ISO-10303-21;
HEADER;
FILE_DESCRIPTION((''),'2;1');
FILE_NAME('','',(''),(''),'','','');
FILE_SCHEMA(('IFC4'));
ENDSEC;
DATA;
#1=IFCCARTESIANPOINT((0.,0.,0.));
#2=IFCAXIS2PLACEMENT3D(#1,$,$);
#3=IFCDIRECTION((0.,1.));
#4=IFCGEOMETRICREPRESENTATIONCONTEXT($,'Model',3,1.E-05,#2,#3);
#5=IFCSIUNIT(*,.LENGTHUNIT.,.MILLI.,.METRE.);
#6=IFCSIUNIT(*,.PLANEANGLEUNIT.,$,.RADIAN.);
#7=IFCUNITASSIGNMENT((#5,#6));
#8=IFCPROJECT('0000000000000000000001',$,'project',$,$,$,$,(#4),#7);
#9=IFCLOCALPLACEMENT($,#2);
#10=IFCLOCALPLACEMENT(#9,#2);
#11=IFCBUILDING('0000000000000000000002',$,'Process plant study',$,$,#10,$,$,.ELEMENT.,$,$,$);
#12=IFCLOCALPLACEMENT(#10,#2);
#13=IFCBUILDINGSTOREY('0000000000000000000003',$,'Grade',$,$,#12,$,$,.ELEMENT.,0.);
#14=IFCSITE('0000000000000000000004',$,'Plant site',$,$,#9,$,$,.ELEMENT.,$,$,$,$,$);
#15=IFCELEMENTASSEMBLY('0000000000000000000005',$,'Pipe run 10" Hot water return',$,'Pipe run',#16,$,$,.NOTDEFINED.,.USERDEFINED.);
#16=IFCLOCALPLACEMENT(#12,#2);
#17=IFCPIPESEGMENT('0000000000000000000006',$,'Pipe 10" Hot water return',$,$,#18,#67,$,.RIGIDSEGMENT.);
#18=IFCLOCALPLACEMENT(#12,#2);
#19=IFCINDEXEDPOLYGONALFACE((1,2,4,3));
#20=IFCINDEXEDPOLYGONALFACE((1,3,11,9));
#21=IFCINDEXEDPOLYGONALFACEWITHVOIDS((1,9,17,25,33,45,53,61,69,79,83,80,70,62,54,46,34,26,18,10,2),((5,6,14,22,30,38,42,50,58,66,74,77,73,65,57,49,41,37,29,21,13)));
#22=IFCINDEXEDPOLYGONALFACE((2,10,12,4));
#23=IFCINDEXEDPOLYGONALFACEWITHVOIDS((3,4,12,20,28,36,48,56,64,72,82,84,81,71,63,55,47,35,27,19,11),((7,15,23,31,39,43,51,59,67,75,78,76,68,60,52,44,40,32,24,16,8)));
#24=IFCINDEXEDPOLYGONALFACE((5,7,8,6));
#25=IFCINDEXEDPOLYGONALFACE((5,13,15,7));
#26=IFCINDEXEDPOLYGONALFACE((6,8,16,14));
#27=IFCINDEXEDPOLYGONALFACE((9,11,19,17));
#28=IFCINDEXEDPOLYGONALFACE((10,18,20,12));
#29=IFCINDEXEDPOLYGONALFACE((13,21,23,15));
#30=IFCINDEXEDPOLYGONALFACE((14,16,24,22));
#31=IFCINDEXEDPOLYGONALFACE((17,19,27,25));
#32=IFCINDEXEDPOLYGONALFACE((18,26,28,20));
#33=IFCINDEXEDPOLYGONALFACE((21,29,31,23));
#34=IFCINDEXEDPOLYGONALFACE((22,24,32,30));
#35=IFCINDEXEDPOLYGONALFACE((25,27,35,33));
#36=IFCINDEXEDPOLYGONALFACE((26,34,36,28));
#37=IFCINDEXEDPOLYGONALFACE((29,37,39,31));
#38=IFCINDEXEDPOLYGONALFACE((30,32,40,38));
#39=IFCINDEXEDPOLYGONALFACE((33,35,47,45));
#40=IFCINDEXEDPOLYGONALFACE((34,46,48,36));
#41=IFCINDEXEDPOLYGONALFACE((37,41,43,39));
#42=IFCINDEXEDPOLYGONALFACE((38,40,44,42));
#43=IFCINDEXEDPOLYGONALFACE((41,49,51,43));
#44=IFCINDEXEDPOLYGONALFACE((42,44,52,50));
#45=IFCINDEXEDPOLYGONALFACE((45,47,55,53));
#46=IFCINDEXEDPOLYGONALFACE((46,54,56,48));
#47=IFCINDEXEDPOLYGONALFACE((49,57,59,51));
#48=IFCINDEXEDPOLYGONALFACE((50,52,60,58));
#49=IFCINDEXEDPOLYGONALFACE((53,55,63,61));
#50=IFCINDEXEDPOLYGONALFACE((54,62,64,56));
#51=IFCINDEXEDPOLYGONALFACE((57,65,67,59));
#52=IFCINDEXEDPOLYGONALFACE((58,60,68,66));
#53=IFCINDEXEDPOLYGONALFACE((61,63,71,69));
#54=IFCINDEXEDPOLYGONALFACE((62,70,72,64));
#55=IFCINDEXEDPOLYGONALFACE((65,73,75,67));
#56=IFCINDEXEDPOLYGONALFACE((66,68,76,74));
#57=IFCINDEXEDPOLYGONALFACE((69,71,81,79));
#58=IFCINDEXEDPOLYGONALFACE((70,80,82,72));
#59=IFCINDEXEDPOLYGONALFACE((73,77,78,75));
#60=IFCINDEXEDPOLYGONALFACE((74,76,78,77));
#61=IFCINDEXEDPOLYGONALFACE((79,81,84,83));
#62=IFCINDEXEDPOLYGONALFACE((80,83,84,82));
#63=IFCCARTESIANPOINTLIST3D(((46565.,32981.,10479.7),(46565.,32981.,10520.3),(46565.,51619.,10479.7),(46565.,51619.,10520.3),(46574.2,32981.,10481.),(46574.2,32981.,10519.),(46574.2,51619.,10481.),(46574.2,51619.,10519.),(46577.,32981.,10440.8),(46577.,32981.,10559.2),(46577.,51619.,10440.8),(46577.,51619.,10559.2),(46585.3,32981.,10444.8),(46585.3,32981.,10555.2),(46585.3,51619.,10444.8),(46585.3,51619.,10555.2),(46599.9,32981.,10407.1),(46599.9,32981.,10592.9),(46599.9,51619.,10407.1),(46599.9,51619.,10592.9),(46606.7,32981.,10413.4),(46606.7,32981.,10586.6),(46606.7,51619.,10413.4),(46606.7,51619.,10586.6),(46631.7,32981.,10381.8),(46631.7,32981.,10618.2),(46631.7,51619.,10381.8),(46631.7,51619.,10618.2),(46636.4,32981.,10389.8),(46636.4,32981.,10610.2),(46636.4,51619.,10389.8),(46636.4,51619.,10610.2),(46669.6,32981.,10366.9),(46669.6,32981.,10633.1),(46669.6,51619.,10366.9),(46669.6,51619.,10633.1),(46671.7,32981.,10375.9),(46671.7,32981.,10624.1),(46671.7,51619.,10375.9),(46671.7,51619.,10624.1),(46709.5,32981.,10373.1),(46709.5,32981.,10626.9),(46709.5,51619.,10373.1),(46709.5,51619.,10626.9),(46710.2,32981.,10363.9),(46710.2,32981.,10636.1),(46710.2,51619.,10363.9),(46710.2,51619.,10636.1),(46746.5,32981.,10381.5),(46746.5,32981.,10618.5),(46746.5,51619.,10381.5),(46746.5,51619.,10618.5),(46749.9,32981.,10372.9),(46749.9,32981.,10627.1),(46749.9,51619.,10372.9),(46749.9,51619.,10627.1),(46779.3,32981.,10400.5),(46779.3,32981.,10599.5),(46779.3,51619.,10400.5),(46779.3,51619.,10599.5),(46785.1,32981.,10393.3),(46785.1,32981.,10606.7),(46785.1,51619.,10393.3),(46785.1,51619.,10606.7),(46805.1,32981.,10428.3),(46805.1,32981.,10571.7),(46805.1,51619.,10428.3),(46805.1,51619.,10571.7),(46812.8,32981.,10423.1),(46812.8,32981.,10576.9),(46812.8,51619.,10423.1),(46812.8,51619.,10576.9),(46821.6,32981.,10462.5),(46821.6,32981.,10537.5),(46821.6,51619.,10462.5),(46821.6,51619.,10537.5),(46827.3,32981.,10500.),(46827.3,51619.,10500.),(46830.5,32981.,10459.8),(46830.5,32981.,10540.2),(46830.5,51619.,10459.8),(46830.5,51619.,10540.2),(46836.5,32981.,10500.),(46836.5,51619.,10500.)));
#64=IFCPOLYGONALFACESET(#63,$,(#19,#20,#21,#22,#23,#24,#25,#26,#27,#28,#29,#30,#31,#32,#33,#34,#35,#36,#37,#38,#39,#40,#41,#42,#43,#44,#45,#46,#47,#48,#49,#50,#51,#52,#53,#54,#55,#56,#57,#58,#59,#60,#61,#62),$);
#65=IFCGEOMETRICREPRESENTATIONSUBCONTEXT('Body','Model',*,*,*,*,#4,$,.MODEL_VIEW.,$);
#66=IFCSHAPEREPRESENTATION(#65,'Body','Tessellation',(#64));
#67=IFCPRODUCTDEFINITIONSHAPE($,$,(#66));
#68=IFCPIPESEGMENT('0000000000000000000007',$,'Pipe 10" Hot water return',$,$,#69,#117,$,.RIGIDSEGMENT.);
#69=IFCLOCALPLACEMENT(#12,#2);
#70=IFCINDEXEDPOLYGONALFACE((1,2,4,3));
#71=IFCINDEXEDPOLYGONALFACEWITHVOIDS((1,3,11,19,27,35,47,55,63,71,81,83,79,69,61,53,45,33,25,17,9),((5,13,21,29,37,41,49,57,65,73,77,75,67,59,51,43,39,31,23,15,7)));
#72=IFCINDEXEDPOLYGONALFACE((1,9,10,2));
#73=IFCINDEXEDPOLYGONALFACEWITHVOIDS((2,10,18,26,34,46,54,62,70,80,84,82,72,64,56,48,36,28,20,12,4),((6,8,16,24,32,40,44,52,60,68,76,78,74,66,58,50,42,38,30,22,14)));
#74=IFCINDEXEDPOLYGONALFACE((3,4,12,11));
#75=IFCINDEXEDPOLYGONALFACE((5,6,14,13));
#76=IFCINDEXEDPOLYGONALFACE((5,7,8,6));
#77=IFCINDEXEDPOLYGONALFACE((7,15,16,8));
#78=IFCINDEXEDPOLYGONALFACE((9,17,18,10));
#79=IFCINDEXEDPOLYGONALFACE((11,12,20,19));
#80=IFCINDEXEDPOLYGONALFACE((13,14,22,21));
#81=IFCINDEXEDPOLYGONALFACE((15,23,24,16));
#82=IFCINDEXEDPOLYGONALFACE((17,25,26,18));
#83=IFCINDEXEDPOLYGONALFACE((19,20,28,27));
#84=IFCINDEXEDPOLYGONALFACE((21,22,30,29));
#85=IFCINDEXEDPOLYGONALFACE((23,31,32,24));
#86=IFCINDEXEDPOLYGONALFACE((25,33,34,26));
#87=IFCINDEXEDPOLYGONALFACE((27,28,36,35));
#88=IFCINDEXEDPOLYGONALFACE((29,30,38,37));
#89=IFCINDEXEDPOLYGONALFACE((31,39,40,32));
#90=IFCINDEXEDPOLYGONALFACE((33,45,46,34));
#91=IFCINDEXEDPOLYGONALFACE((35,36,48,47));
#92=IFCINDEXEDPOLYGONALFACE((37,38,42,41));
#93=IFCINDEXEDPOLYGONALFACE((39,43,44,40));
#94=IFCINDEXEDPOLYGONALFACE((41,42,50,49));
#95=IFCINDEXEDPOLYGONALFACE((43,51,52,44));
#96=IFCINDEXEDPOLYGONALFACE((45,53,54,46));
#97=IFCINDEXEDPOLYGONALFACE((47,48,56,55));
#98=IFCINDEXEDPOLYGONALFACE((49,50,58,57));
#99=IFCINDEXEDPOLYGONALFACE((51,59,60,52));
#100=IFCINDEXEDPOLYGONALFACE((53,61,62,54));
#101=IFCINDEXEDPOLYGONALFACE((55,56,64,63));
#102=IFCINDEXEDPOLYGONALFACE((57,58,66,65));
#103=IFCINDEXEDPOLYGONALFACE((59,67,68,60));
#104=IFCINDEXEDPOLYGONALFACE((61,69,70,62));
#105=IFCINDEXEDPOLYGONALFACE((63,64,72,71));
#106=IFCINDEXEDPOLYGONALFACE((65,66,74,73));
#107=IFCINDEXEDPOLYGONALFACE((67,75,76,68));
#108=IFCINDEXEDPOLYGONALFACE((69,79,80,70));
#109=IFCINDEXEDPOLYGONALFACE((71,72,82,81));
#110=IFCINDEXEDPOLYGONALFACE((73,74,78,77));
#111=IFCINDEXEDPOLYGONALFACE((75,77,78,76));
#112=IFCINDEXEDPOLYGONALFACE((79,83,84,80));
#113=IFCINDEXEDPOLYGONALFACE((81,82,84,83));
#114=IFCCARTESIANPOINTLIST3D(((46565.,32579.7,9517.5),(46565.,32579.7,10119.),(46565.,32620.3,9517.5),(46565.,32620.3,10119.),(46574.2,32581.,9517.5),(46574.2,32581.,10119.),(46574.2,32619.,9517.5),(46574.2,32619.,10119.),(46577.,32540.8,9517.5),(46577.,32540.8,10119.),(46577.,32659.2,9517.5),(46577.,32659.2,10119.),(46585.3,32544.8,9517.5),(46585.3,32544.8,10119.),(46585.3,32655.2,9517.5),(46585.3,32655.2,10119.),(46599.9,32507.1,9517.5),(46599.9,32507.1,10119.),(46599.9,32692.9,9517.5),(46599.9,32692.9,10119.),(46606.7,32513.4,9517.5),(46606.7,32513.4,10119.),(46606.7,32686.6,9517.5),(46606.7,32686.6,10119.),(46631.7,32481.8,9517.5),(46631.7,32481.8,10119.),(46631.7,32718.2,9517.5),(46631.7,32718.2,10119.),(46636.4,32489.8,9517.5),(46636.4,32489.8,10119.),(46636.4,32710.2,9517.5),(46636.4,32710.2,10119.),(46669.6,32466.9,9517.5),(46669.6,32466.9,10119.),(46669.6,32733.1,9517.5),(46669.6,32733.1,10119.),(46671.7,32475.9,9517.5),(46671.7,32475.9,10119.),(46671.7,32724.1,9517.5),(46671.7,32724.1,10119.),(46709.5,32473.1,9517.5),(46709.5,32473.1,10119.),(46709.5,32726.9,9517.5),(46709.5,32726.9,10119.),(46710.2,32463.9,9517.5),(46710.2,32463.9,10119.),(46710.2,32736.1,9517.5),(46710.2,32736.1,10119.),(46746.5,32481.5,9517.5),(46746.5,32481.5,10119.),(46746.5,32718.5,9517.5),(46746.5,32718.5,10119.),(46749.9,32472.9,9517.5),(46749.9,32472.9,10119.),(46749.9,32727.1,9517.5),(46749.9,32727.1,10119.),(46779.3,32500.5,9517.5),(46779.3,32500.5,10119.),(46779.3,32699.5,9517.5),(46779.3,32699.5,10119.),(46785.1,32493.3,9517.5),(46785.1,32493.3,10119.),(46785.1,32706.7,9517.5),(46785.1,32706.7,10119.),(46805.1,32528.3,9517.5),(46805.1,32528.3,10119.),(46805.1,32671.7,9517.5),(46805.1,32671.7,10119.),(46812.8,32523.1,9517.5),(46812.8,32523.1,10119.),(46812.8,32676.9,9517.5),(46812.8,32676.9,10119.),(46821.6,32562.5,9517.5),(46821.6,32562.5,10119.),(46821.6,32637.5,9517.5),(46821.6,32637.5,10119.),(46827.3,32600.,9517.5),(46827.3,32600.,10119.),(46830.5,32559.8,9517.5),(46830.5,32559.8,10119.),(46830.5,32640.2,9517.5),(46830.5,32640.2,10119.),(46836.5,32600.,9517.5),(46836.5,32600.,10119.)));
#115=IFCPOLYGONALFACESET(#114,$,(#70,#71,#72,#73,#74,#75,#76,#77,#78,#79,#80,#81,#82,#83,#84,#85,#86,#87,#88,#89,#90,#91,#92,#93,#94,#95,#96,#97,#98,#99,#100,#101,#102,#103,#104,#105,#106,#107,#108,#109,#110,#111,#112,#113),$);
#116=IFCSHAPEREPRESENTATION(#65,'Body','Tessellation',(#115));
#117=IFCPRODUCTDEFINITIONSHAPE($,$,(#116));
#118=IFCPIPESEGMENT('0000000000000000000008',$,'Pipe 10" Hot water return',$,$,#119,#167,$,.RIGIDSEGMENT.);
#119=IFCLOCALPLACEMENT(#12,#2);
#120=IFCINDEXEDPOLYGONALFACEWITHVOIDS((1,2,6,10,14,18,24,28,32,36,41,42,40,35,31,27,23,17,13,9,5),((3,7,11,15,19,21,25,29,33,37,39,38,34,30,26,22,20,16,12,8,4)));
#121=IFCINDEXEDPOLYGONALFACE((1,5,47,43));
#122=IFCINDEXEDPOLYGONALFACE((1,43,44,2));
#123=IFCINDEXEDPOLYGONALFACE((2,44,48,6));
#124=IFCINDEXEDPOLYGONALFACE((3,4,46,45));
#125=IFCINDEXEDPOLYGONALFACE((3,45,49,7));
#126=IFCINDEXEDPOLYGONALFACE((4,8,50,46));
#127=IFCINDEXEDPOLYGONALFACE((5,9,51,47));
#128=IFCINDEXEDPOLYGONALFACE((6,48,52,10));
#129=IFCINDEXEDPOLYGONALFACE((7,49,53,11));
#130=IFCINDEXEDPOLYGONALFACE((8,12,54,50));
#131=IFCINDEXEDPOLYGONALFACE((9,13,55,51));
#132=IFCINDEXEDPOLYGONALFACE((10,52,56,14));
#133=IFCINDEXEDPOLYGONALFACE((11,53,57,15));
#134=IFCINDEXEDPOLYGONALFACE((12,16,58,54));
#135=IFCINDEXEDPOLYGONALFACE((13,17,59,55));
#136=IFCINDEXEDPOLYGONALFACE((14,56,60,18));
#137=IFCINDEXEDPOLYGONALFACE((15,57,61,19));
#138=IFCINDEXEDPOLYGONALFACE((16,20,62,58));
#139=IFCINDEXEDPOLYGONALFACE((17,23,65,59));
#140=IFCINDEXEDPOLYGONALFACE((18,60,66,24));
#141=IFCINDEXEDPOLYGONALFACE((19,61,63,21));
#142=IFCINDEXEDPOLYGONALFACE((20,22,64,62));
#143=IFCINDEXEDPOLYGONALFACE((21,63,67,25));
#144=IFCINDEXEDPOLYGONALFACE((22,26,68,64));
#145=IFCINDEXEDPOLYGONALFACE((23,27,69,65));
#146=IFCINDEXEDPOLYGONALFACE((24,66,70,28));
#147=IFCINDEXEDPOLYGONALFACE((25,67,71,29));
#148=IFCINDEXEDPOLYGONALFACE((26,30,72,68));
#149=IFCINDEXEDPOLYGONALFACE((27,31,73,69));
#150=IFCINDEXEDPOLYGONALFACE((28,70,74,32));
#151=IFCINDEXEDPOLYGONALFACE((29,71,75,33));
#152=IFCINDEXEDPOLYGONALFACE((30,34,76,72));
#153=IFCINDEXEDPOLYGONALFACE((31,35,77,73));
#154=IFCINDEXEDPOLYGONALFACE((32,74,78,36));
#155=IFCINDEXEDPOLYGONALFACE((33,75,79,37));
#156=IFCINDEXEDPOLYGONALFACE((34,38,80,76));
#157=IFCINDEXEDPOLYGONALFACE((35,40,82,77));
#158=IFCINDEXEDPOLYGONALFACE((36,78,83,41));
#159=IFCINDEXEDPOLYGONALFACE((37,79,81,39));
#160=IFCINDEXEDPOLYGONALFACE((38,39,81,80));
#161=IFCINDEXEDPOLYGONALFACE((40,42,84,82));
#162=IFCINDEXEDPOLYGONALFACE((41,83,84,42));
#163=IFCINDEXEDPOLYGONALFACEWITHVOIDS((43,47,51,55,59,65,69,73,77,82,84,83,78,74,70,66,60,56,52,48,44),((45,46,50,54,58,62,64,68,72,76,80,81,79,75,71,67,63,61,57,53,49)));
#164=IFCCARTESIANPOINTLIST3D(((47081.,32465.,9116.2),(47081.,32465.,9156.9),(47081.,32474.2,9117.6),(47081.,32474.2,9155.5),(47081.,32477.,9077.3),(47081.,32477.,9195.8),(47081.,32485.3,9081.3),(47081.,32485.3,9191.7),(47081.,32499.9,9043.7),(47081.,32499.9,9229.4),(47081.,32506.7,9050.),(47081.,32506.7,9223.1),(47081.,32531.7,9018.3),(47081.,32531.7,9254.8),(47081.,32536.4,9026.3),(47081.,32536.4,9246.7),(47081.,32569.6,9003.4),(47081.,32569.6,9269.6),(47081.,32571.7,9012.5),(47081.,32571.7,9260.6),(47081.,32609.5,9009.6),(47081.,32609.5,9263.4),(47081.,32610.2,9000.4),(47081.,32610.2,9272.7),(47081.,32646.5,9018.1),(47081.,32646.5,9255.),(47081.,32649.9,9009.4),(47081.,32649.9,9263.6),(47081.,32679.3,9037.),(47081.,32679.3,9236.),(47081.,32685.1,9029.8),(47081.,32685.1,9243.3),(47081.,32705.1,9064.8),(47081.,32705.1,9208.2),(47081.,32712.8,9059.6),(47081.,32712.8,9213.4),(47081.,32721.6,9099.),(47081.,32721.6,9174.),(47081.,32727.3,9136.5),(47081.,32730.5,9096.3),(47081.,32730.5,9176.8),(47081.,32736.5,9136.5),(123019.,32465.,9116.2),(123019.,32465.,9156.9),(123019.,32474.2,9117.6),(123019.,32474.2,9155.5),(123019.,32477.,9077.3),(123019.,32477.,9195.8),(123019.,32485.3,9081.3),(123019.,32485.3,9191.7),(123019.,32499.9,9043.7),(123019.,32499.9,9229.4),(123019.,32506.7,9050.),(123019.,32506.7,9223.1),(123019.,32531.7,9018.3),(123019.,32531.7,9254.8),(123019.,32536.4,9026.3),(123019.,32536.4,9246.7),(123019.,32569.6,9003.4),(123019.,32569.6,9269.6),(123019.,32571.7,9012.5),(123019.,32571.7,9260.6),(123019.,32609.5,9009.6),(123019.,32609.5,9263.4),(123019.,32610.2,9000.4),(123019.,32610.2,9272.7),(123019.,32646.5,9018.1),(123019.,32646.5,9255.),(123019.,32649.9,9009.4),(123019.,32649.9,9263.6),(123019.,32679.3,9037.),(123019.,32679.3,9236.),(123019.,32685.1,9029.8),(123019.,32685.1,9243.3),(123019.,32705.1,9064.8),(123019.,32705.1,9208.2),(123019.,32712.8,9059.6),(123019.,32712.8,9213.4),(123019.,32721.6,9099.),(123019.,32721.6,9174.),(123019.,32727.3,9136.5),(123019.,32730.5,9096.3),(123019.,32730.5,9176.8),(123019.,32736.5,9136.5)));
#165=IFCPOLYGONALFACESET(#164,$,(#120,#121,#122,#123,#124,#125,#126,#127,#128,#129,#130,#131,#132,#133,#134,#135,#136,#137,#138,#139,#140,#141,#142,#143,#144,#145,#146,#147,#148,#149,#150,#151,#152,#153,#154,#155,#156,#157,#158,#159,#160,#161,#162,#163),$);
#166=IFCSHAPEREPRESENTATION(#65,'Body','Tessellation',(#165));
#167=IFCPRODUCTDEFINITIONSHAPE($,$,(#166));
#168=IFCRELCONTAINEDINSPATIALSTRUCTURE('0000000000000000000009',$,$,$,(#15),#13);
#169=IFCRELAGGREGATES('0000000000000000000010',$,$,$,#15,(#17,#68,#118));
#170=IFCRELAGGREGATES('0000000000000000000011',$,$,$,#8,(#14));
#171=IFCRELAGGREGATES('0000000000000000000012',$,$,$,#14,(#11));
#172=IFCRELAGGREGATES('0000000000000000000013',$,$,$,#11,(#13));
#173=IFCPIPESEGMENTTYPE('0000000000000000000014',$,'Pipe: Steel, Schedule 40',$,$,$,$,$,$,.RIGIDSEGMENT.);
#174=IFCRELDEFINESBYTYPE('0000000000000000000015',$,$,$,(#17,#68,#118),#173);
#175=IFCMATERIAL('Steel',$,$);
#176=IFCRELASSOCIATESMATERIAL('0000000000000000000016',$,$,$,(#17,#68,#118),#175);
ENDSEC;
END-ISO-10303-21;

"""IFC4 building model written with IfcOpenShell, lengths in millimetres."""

from ifc_helpers import new_model, si_unit, direction, frame, origin, origin_with_axes, origin_2d, place, context, subcontext, project, spatial, hollow_circle, extrude, material, type_object, element, aggregate, save


model = new_model("IFC4")

# Units and contexts
model_context = context("Model", 3, precision=1e-05, world=origin(), true_north=direction((0.0, 1.0)))
body_context = subcontext(model_context, "Body", "Model", "MODEL_VIEW")
ifc_project = project(units=[si_unit("LENGTHUNIT", "METRE", prefix="MILLI"), si_unit("PLANEANGLEUNIT", "RADIAN")], contexts=[model_context])

# Site, building, storey
site_placement = place(None, origin())
site = spatial("IfcSite", under=ifc_project, at=site_placement, Name="Plant site", CompositionType="ELEMENT")
building_placement = place(site_placement, origin())
building = spatial("IfcBuilding", under=site, at=building_placement, Name="Process plant study", CompositionType="ELEMENT")
storey_placement = place(building_placement, origin())
storey = spatial("IfcBuildingStorey", under=building, at=storey_placement, Name="Grade", CompositionType="ELEMENT", Elevation=0.0)

# Shared definitions
ifc_material = material(Name="Steel")
pipe_segment_type = type_object("IfcPipeSegmentType", Name="Pipe: Steel, Schedule 40", PredefinedType="RIGIDSEGMENT")

# Element assembly, pipe segments
assembly_1_placement = place(storey_placement, origin_with_axes())
assembly_1 = element("IfcElementAssembly", 1, at=assembly_1_placement, inside=storey, Name="Pipe run 10\" Hot water return", ObjectType="Pipe run", AssemblyPlace="NOTDEFINED", PredefinedType="USERDEFINED")
pipe_segment_1_placement = place(storey_placement, origin_with_axes())
pipe_segment_1 = element("IfcPipeSegment", 2, at=pipe_segment_1_placement, type_object=pipe_segment_type, material=ifc_material, Name="Pipe 10\" Hot water return", PredefinedType="RIGIDSEGMENT", context=body_context, shape_type="SweptSolid", body=[
    extrude(hollow_circle(Radius=136.5, WallThickness=9.3, at=origin_2d()), frame((46700.0, 51619.0, 10500.0), z_axis=(0.0, -1.0, 0.0), x_axis=(1.0, 0.0, 0.0)), (0.0, 0.0, 1.0), 18638.0),
])
pipe_segment_2_placement = place(storey_placement, origin_with_axes())
pipe_segment_2 = element("IfcPipeSegment", 3, at=pipe_segment_2_placement, type_object=pipe_segment_type, material=ifc_material, Name="Pipe 10\" Hot water return", PredefinedType="RIGIDSEGMENT", context=body_context, shape_type="SweptSolid", body=[
    extrude(hollow_circle(Radius=136.5, WallThickness=9.3, at=origin_2d()), frame((46700.0, 32600.0, 10119.0), z_axis=(0.0, 0.0, -1.0), x_axis=(1.0, 0.0, 0.0)), (0.0, 0.0, 1.0), 601.5),
])
pipe_segment_3_placement = place(storey_placement, origin_with_axes())
pipe_segment_3 = element("IfcPipeSegment", 4, at=pipe_segment_3_placement, type_object=pipe_segment_type, material=ifc_material, Name="Pipe 10\" Hot water return", PredefinedType="RIGIDSEGMENT", context=body_context, shape_type="SweptSolid", body=[
    extrude(hollow_circle(Radius=136.5, WallThickness=9.3, at=origin_2d()), frame((47081.0, 32600.0, 9136.5), z_axis=(1.0, 0.0, 0.0), x_axis=(0.0, 1.0, 0.0)), (0.0, 0.0, 1.0), 75938.0),
])

aggregate(assembly_1, [pipe_segment_1, pipe_segment_2, pipe_segment_3])

save(model, "model.ifc")
